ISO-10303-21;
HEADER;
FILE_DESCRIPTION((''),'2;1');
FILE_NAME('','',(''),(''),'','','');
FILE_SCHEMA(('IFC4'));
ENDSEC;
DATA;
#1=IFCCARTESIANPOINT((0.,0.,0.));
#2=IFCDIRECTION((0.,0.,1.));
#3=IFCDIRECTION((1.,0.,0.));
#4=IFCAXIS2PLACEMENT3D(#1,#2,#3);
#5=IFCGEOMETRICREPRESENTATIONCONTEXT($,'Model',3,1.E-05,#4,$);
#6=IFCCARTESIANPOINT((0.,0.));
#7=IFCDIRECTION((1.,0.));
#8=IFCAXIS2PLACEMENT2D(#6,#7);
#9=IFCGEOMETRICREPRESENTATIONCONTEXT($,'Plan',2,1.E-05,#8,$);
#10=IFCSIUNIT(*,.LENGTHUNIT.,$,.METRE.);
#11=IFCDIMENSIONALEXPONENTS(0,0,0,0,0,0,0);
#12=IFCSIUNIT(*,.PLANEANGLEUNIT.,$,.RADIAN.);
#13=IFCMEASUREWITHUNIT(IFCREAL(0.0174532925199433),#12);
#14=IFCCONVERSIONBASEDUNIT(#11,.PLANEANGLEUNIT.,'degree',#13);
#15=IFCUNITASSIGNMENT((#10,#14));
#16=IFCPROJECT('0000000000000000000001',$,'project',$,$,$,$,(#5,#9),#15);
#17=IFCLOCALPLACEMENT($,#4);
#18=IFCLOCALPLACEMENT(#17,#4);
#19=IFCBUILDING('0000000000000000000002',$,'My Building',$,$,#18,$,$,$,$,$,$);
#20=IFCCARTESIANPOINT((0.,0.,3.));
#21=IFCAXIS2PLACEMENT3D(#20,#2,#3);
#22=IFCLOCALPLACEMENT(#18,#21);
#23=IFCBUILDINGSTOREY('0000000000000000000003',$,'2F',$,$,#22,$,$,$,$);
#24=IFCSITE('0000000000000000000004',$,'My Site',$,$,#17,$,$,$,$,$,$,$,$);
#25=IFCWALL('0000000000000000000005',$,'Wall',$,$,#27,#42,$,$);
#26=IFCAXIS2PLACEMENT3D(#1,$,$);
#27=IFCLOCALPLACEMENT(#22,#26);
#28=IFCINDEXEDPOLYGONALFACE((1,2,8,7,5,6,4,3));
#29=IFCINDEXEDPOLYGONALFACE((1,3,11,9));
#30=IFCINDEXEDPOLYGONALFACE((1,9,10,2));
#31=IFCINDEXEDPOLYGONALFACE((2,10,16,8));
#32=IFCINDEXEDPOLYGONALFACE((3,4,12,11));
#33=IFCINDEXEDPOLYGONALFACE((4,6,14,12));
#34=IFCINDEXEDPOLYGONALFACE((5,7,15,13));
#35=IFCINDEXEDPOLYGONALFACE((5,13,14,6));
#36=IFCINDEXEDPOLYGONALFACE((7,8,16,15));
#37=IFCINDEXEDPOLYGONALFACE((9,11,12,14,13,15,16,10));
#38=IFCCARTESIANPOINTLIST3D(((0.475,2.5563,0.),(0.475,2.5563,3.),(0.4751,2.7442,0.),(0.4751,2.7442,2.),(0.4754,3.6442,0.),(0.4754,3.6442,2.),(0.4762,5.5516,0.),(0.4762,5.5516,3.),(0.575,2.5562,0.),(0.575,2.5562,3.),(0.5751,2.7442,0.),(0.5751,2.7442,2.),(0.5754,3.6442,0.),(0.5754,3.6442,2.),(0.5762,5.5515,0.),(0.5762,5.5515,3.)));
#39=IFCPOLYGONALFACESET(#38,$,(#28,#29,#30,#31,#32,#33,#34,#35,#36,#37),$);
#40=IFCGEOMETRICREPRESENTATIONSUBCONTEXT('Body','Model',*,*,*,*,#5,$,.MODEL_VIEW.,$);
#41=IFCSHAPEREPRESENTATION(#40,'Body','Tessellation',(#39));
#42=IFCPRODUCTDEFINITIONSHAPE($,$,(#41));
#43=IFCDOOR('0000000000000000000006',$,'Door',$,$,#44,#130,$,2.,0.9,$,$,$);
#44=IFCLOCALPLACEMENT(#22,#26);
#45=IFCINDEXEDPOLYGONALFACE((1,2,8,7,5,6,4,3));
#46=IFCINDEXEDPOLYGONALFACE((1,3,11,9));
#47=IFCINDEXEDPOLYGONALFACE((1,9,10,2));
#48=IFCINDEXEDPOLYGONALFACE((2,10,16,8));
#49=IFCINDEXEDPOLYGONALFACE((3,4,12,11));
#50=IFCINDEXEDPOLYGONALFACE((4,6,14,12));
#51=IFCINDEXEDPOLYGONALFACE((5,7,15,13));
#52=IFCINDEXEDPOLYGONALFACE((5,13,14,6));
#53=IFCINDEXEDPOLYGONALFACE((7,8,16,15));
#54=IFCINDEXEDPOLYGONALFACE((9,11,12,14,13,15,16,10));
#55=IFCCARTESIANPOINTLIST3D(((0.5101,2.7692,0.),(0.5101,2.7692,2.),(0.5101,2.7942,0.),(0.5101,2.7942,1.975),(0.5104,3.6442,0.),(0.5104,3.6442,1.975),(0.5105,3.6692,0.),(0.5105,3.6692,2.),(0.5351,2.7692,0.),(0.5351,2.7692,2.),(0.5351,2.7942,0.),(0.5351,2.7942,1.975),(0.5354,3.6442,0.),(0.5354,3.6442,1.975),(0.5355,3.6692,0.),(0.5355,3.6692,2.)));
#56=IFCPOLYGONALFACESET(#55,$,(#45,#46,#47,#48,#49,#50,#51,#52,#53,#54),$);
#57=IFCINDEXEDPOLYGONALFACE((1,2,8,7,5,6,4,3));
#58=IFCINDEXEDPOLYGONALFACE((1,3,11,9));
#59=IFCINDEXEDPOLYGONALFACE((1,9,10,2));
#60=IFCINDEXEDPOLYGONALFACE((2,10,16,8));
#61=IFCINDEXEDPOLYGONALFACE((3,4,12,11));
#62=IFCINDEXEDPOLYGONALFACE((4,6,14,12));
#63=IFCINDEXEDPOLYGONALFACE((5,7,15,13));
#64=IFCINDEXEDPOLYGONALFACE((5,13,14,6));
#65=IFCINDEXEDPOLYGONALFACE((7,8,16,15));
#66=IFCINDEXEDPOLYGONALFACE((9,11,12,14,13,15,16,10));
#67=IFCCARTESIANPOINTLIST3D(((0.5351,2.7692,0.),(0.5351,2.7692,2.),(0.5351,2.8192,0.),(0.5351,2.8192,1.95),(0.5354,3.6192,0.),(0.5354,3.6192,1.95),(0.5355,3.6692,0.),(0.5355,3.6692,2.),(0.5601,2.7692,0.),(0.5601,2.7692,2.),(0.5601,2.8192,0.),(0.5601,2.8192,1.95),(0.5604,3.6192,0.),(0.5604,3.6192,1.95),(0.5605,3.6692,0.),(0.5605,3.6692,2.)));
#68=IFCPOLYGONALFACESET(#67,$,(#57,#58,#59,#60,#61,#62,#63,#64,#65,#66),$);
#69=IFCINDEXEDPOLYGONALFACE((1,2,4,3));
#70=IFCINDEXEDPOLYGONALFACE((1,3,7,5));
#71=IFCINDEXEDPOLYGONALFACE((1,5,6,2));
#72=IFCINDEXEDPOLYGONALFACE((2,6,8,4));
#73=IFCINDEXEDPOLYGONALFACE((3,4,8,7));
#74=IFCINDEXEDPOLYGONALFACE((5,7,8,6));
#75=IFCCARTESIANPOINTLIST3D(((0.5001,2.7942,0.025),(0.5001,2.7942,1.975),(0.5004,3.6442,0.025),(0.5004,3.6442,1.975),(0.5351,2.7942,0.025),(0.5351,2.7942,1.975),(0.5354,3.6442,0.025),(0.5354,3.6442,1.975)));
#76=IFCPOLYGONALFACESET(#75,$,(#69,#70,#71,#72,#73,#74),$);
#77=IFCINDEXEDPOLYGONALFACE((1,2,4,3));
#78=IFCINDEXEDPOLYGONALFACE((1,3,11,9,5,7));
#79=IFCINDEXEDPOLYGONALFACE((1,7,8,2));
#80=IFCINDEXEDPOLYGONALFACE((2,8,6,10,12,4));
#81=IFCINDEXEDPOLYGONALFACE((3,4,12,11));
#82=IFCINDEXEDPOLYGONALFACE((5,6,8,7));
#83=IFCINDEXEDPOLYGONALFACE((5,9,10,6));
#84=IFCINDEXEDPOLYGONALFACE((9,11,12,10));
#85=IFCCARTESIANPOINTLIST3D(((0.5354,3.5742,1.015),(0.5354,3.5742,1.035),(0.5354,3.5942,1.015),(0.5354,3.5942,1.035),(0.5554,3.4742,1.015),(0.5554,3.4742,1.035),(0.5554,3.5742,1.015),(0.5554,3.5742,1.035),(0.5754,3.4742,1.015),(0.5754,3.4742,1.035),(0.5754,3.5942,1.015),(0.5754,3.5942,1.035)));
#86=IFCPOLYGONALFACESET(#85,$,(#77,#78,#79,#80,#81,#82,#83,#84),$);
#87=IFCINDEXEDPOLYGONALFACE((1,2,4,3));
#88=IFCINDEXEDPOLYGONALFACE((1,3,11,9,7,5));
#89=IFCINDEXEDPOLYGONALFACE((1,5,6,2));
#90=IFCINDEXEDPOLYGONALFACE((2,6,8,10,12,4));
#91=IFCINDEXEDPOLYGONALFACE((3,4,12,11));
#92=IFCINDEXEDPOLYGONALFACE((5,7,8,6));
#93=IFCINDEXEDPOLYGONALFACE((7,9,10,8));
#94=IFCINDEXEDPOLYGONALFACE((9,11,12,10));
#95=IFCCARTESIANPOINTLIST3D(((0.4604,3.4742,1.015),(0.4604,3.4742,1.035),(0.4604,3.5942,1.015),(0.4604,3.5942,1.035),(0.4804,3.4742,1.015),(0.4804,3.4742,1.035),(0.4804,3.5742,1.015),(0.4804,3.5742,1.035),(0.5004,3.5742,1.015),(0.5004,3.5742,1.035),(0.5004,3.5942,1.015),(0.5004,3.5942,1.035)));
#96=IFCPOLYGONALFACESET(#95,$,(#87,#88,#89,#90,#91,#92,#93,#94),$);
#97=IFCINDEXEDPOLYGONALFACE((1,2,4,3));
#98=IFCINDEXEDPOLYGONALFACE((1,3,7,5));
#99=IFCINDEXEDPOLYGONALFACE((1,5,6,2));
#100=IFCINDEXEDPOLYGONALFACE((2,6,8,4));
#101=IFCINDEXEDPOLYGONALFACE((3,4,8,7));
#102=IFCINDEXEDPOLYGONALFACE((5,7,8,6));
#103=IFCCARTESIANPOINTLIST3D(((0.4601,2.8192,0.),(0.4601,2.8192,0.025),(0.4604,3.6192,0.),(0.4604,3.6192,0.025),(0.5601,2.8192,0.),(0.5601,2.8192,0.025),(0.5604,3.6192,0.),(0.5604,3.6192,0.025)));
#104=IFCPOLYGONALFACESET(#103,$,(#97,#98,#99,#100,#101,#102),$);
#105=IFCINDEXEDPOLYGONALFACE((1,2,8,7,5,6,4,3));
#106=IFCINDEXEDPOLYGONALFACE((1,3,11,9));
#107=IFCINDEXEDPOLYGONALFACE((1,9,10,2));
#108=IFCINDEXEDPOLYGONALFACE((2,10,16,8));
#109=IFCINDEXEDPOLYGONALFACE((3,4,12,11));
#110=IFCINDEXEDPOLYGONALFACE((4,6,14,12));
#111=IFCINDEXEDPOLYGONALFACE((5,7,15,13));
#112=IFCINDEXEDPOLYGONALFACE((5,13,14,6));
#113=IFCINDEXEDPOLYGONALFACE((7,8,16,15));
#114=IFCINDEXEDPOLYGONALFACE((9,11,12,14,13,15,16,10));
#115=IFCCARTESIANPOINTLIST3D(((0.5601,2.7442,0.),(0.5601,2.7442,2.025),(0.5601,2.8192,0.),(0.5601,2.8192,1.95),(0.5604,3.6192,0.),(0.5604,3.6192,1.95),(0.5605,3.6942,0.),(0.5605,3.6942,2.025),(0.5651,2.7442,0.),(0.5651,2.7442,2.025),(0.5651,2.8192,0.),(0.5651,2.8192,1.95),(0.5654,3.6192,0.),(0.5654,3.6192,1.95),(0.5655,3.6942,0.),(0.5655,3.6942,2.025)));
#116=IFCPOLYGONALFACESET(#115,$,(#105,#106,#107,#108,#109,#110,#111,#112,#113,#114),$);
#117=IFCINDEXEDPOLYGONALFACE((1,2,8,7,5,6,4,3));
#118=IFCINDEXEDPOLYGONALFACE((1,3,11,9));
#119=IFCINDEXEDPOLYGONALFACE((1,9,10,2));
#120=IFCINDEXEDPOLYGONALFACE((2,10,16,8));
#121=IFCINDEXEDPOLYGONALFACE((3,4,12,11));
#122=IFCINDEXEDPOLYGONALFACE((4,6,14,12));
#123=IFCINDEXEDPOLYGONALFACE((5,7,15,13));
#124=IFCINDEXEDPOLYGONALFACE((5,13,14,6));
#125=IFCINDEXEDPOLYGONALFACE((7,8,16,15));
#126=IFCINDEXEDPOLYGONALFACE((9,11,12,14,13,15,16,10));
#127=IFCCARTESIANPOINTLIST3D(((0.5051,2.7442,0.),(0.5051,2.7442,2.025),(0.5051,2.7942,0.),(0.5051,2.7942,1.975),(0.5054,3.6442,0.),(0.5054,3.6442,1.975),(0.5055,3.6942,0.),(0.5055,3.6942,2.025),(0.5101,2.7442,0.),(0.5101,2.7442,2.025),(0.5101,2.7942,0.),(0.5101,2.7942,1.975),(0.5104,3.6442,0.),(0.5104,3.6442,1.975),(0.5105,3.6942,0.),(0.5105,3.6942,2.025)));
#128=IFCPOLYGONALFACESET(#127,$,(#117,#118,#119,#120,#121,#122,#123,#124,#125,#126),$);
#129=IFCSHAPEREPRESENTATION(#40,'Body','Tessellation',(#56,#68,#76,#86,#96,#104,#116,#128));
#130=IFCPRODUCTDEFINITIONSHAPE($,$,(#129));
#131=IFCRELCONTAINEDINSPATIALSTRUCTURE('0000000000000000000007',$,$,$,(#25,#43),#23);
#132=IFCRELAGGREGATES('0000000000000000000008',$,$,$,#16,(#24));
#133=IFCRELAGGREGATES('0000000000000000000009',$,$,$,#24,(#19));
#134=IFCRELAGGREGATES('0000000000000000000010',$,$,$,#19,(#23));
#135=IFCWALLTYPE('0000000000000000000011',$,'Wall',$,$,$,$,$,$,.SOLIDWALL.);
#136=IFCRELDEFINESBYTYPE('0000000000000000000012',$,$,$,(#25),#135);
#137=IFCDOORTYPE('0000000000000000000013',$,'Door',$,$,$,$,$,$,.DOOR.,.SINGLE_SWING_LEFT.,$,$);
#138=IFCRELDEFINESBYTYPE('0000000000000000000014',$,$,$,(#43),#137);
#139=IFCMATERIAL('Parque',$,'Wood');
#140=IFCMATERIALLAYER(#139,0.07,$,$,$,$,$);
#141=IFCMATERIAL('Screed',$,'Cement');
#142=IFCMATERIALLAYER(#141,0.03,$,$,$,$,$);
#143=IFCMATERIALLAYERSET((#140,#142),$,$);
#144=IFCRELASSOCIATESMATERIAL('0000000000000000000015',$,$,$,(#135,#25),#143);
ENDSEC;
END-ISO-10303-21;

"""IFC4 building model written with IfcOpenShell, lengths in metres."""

from ifc_helpers import new_model, entity, si_unit, converted_unit, frame, origin_with_axes, origin_2d_with_axis, place, context, subcontext, project, spatial, line, indexed_curve, outline, extrude, shape, source, transform, mapped, material, layer, layer_set, layer_usage, type_object, type_shapes, element, fill, save


model = new_model("IFC4")

# Units and contexts
model_context = context("Model", 3, precision=1e-05, world=origin_with_axes())
plan_context = context("Plan", 2, precision=1e-05, world=origin_2d_with_axis())
body_context_1 = subcontext(model_context, "Body", "Model", "MODEL_VIEW")
body_context_2 = subcontext(plan_context, "Body", "Plan", "PLAN_VIEW")
ifc_project = project(units=[si_unit("LENGTHUNIT", "METRE"), converted_unit("PLANEANGLEUNIT", "degree", entity("IfcReal", 0.0174532925199433), si_unit("PLANEANGLEUNIT", "RADIAN"), dimensions=[0, 0, 0, 0, 0, 0, 0])], contexts=[model_context, plan_context])

# Site, building, storey
site_placement = place(None, origin_with_axes())
site = spatial("IfcSite", under=ifc_project, at=site_placement, Name="My Site")
building_placement = place(site_placement, origin_with_axes())
building = spatial("IfcBuilding", under=site, at=building_placement, Name="My Building")
storey_placement = place(building_placement, frame((0.0, 0.0, 3.0), z_axis=(0.0, 0.0, 1.0), x_axis=(1.0, 0.0, 0.0)))
storey = spatial("IfcBuildingStorey", under=building, at=storey_placement, Name="2F")

# Shared definitions
ifc_material_1 = material(Name="Parque", Category="Wood")
ifc_layer_1 = layer(ifc_material_1, 0.07)
ifc_material_2 = material(Name="Screed", Category="Cement")
ifc_layer_2 = layer(ifc_material_2, 0.03)
ifc_layer_set = layer_set([ifc_layer_1, ifc_layer_2])
wall_type = type_object("IfcWallType", Name="Wall", PredefinedType="SOLIDWALL", material=ifc_layer_set)

# Wall, opening, door
ifc_layer_usage_1 = layer_usage(ifc_layer_set, "AXIS2", "POSITIVE", 0.0)
wall_1_placement = place(storey_placement, frame((0.4762, 5.5516, 0.0), z_axis=(0.0, 0.0, 1.0), x_axis=(-0.000399, -1.0, 0.0)))
wall_1 = element("IfcWall", 1, at=wall_1_placement, inside=storey, type_object=wall_type, material=ifc_layer_usage_1, Name="Wall", context=body_context_1, shape_type="SweptSolid", body=[
    extrude(outline(indexed_curve([(0.0, 0.0), (0.0, 0.1), (2.9953, 0.1), (2.9953, 0.0)], segments=[line(1, 2, 3, 4, 1)])), origin_with_axes(), (0.0, 0.0, 1.0), 3.0),
])
shared_shape_1 = source(origin_with_axes(), body_context_1, "Body", "SweptSolid", [
    extrude(outline(indexed_curve([(0.0, 0.0), (0.9, 0.0), (0.9, 2.0), (0.0, 2.0)], segments=[line(1, 2, 3, 4, 1)])), frame((0.0, -0.6, 0.0), z_axis=(0.0, -1.0, 0.0), x_axis=(1.0, 0.0, 0.0)), (0.0, 0.0, -1.0), 1.2),
])
opening_1_placement = place(wall_1_placement, frame((1.9074, 0.0, 0.0), z_axis=(0.0, 0.0, 1.0), x_axis=(1.0, 0.0, 0.0)))
opening_1 = element("IfcOpeningElement", 2, at=opening_1_placement, cuts=wall_1, PredefinedType="OPENING", context=body_context_1, shape_type="MappedRepresentation", body=[
    mapped(shared_shape_1, transform((0.0, 0.0, 0.0), x_axis=(1.0, 0.0, 0.0), y_axis=(0.0, 1.0, 0.0), z_axis=(0.0, 0.0, 1.0), scale=1.0)),
])
door_type_1 = type_object("IfcDoorType", Name="Door", OperationType="SINGLE_SWING_LEFT", PredefinedType="DOOR")
shared_shape_2 = source(origin_with_axes(), body_context_1, "Body", "SweptSolid", [
    extrude(outline(indexed_curve([(0.0, 0.0), (0.0, 2.0), (0.9, 2.0), (0.9, 0.0), (0.875, 0.0), (0.875, 1.975), (0.025, 1.975), (0.025, 0.0)], segments=[line(1, 2, 3, 4, 5, 6, 7, 8, 1)])), frame((0.0, 0.025, 0.0), z_axis=(0.0, -1.0, 0.0), x_axis=(1.0, 0.0, 0.0)), (0.0, 0.0, -1.0), 0.025),
    extrude(outline(indexed_curve([(0.0, 0.0), (0.0, 2.0), (0.9, 2.0), (0.9, 0.0), (0.85, 0.0), (0.85, 1.95), (0.05, 1.95), (0.05, 0.0)], segments=[line(1, 2, 3, 4, 5, 6, 7, 8, 1)])), frame((0.0, 0.0, 0.0), z_axis=(0.0, -1.0, 0.0), x_axis=(1.0, 0.0, 0.0)), (0.0, 0.0, -1.0), 0.025),
    extrude(outline(indexed_curve([(0.0, 0.0), (0.85, 0.0), (0.85, 0.035), (0.0, 0.035)], segments=[line(1, 2, 3, 4, 1)])), frame((0.025, 0.025, 0.025), z_axis=(0.0, 0.0, 1.0), x_axis=(1.0, 0.0, 0.0)), (0.0, 0.0, 1.0), 1.95),
    extrude(outline(indexed_curve([(0.0, 0.0), (0.0, -0.04), (-0.12, -0.04), (-0.12, -0.02), (-0.02, -0.02), (-0.02, 0.0)], segments=[line(1, 2, 3, 4, 5, 6, 1)])), frame((0.825, 0.025, 1.015), z_axis=(0.0, 0.0, 1.0), x_axis=(1.0, 0.0, 0.0)), (0.0, 0.0, 1.0), 0.02),
    extrude(outline(indexed_curve([(0.0, 0.0), (0.0, 0.04), (-0.12, 0.04), (-0.12, 0.02), (-0.02, 0.02), (-0.02, 0.0)], segments=[line(1, 2, 3, 4, 5, 6, 1)])), frame((0.825, 0.06, 1.015), z_axis=(0.0, 0.0, 1.0), x_axis=(1.0, 0.0, 0.0)), (0.0, 0.0, 1.0), 0.02),
    extrude(outline(indexed_curve([(0.0, 0.0), (0.8, 0.0), (0.8, 0.1), (0.0, 0.1)], segments=[line(1, 2, 3, 4, 1)])), frame((0.05, 0.0, 0.0), z_axis=(0.0, 0.0, 1.0), x_axis=(1.0, 0.0, 0.0)), (0.0, 0.0, 1.0), 0.025),
    extrude(outline(indexed_curve([(0.0, 0.0), (0.0, 2.025), (0.95, 2.025), (0.95, 0.0), (0.875, 0.0), (0.875, 1.95), (0.075, 1.95), (0.075, 0.0)], segments=[line(1, 2, 3, 4, 5, 6, 7, 8, 1)])), frame((-0.025, -0.005, 0.0), z_axis=(0.0, -1.0, 0.0), x_axis=(1.0, 0.0, 0.0)), (0.0, 0.0, -1.0), 0.005),
    extrude(outline(indexed_curve([(0.0, 0.0), (0.0, 2.025), (0.95, 2.025), (0.95, 0.0), (0.9, 0.0), (0.9, 1.975), (0.05, 1.975), (0.05, 0.0)], segments=[line(1, 2, 3, 4, 5, 6, 7, 8, 1)])), frame((-0.025, 0.05, 0.0), z_axis=(0.0, -1.0, 0.0), x_axis=(1.0, 0.0, 0.0)), (0.0, 0.0, -1.0), 0.005),
])
shared_shape_3 = source(origin_with_axes(), body_context_2, "Body", "Curve2D", [
    entity("IfcIndexedPolyCurve", entity("IfcCartesianPointList2D", [[0.0, 0.0], [0.0, 0.05], [0.025, 0.05], [0.025, 0.025], [0.05, 0.025], [0.05, 0.0]]), [entity("IfcLineIndex", [1, 2, 3, 4, 5, 6, 1])]),
    entity("IfcIndexedPolyCurve", entity("IfcCartesianPointList2D", [[0.9, 0.0], [0.9, 0.05], [0.875, 0.05], [0.875, 0.025], [0.85, 0.025], [0.85, 0.0]]), [entity("IfcLineIndex", [1, 2, 3, 4, 5, 6, 1])]),
    entity("IfcTrimmedCurve", entity("IfcEllipse", entity("IfcAxis2Placement2D", entity("IfcCartesianPoint", [0.06, 0.05]), entity("IfcDirection", [1.0, 0.0])), 0.815, 0.85), [entity("IfcCartesianPoint", [0.875, 0.05])], [entity("IfcCartesianPoint", [0.06, 0.9])], True, "CARTESIAN"),
    entity("IfcIndexedPolyCurve", entity("IfcCartesianPointList2D", [[0.025, 0.05], [0.06, 0.05], [0.06, 0.9], [0.025, 0.9]]), [entity("IfcLineIndex", [1, 2, 3, 4, 1])]),
])
type_shapes(door_type_1, [shared_shape_2, shared_shape_3])
door_1_placement = place(opening_1_placement, frame((0.875, 0.085, 0.0), z_axis=(0.0, 0.0, 1.0), x_axis=(-1.0, 0.0, 0.0)))
door_1 = element("IfcDoor", 3, at=door_1_placement, inside=storey, type_object=door_type_1, Name="Door", OverallHeight=2.0, OverallWidth=0.9, shapes=[
    shape(body_context_1, "Body", "MappedRepresentation", [mapped(shared_shape_2, transform((0.0, 0.0, 0.0), x_axis=(1.0, 0.0, 0.0), y_axis=(0.0, 1.0, 0.0), z_axis=(0.0, 0.0, 1.0), scale=1.0))]),
    shape(body_context_2, "Body", "MappedRepresentation", [mapped(shared_shape_3, transform((0.0, 0.0, 0.0), x_axis=(1.0, 0.0, 0.0), y_axis=(0.0, 1.0, 0.0), z_axis=(0.0, 0.0, 1.0), scale=1.0))]),
])
fill(opening_1, door_1)

save(model, "model.ifc")
